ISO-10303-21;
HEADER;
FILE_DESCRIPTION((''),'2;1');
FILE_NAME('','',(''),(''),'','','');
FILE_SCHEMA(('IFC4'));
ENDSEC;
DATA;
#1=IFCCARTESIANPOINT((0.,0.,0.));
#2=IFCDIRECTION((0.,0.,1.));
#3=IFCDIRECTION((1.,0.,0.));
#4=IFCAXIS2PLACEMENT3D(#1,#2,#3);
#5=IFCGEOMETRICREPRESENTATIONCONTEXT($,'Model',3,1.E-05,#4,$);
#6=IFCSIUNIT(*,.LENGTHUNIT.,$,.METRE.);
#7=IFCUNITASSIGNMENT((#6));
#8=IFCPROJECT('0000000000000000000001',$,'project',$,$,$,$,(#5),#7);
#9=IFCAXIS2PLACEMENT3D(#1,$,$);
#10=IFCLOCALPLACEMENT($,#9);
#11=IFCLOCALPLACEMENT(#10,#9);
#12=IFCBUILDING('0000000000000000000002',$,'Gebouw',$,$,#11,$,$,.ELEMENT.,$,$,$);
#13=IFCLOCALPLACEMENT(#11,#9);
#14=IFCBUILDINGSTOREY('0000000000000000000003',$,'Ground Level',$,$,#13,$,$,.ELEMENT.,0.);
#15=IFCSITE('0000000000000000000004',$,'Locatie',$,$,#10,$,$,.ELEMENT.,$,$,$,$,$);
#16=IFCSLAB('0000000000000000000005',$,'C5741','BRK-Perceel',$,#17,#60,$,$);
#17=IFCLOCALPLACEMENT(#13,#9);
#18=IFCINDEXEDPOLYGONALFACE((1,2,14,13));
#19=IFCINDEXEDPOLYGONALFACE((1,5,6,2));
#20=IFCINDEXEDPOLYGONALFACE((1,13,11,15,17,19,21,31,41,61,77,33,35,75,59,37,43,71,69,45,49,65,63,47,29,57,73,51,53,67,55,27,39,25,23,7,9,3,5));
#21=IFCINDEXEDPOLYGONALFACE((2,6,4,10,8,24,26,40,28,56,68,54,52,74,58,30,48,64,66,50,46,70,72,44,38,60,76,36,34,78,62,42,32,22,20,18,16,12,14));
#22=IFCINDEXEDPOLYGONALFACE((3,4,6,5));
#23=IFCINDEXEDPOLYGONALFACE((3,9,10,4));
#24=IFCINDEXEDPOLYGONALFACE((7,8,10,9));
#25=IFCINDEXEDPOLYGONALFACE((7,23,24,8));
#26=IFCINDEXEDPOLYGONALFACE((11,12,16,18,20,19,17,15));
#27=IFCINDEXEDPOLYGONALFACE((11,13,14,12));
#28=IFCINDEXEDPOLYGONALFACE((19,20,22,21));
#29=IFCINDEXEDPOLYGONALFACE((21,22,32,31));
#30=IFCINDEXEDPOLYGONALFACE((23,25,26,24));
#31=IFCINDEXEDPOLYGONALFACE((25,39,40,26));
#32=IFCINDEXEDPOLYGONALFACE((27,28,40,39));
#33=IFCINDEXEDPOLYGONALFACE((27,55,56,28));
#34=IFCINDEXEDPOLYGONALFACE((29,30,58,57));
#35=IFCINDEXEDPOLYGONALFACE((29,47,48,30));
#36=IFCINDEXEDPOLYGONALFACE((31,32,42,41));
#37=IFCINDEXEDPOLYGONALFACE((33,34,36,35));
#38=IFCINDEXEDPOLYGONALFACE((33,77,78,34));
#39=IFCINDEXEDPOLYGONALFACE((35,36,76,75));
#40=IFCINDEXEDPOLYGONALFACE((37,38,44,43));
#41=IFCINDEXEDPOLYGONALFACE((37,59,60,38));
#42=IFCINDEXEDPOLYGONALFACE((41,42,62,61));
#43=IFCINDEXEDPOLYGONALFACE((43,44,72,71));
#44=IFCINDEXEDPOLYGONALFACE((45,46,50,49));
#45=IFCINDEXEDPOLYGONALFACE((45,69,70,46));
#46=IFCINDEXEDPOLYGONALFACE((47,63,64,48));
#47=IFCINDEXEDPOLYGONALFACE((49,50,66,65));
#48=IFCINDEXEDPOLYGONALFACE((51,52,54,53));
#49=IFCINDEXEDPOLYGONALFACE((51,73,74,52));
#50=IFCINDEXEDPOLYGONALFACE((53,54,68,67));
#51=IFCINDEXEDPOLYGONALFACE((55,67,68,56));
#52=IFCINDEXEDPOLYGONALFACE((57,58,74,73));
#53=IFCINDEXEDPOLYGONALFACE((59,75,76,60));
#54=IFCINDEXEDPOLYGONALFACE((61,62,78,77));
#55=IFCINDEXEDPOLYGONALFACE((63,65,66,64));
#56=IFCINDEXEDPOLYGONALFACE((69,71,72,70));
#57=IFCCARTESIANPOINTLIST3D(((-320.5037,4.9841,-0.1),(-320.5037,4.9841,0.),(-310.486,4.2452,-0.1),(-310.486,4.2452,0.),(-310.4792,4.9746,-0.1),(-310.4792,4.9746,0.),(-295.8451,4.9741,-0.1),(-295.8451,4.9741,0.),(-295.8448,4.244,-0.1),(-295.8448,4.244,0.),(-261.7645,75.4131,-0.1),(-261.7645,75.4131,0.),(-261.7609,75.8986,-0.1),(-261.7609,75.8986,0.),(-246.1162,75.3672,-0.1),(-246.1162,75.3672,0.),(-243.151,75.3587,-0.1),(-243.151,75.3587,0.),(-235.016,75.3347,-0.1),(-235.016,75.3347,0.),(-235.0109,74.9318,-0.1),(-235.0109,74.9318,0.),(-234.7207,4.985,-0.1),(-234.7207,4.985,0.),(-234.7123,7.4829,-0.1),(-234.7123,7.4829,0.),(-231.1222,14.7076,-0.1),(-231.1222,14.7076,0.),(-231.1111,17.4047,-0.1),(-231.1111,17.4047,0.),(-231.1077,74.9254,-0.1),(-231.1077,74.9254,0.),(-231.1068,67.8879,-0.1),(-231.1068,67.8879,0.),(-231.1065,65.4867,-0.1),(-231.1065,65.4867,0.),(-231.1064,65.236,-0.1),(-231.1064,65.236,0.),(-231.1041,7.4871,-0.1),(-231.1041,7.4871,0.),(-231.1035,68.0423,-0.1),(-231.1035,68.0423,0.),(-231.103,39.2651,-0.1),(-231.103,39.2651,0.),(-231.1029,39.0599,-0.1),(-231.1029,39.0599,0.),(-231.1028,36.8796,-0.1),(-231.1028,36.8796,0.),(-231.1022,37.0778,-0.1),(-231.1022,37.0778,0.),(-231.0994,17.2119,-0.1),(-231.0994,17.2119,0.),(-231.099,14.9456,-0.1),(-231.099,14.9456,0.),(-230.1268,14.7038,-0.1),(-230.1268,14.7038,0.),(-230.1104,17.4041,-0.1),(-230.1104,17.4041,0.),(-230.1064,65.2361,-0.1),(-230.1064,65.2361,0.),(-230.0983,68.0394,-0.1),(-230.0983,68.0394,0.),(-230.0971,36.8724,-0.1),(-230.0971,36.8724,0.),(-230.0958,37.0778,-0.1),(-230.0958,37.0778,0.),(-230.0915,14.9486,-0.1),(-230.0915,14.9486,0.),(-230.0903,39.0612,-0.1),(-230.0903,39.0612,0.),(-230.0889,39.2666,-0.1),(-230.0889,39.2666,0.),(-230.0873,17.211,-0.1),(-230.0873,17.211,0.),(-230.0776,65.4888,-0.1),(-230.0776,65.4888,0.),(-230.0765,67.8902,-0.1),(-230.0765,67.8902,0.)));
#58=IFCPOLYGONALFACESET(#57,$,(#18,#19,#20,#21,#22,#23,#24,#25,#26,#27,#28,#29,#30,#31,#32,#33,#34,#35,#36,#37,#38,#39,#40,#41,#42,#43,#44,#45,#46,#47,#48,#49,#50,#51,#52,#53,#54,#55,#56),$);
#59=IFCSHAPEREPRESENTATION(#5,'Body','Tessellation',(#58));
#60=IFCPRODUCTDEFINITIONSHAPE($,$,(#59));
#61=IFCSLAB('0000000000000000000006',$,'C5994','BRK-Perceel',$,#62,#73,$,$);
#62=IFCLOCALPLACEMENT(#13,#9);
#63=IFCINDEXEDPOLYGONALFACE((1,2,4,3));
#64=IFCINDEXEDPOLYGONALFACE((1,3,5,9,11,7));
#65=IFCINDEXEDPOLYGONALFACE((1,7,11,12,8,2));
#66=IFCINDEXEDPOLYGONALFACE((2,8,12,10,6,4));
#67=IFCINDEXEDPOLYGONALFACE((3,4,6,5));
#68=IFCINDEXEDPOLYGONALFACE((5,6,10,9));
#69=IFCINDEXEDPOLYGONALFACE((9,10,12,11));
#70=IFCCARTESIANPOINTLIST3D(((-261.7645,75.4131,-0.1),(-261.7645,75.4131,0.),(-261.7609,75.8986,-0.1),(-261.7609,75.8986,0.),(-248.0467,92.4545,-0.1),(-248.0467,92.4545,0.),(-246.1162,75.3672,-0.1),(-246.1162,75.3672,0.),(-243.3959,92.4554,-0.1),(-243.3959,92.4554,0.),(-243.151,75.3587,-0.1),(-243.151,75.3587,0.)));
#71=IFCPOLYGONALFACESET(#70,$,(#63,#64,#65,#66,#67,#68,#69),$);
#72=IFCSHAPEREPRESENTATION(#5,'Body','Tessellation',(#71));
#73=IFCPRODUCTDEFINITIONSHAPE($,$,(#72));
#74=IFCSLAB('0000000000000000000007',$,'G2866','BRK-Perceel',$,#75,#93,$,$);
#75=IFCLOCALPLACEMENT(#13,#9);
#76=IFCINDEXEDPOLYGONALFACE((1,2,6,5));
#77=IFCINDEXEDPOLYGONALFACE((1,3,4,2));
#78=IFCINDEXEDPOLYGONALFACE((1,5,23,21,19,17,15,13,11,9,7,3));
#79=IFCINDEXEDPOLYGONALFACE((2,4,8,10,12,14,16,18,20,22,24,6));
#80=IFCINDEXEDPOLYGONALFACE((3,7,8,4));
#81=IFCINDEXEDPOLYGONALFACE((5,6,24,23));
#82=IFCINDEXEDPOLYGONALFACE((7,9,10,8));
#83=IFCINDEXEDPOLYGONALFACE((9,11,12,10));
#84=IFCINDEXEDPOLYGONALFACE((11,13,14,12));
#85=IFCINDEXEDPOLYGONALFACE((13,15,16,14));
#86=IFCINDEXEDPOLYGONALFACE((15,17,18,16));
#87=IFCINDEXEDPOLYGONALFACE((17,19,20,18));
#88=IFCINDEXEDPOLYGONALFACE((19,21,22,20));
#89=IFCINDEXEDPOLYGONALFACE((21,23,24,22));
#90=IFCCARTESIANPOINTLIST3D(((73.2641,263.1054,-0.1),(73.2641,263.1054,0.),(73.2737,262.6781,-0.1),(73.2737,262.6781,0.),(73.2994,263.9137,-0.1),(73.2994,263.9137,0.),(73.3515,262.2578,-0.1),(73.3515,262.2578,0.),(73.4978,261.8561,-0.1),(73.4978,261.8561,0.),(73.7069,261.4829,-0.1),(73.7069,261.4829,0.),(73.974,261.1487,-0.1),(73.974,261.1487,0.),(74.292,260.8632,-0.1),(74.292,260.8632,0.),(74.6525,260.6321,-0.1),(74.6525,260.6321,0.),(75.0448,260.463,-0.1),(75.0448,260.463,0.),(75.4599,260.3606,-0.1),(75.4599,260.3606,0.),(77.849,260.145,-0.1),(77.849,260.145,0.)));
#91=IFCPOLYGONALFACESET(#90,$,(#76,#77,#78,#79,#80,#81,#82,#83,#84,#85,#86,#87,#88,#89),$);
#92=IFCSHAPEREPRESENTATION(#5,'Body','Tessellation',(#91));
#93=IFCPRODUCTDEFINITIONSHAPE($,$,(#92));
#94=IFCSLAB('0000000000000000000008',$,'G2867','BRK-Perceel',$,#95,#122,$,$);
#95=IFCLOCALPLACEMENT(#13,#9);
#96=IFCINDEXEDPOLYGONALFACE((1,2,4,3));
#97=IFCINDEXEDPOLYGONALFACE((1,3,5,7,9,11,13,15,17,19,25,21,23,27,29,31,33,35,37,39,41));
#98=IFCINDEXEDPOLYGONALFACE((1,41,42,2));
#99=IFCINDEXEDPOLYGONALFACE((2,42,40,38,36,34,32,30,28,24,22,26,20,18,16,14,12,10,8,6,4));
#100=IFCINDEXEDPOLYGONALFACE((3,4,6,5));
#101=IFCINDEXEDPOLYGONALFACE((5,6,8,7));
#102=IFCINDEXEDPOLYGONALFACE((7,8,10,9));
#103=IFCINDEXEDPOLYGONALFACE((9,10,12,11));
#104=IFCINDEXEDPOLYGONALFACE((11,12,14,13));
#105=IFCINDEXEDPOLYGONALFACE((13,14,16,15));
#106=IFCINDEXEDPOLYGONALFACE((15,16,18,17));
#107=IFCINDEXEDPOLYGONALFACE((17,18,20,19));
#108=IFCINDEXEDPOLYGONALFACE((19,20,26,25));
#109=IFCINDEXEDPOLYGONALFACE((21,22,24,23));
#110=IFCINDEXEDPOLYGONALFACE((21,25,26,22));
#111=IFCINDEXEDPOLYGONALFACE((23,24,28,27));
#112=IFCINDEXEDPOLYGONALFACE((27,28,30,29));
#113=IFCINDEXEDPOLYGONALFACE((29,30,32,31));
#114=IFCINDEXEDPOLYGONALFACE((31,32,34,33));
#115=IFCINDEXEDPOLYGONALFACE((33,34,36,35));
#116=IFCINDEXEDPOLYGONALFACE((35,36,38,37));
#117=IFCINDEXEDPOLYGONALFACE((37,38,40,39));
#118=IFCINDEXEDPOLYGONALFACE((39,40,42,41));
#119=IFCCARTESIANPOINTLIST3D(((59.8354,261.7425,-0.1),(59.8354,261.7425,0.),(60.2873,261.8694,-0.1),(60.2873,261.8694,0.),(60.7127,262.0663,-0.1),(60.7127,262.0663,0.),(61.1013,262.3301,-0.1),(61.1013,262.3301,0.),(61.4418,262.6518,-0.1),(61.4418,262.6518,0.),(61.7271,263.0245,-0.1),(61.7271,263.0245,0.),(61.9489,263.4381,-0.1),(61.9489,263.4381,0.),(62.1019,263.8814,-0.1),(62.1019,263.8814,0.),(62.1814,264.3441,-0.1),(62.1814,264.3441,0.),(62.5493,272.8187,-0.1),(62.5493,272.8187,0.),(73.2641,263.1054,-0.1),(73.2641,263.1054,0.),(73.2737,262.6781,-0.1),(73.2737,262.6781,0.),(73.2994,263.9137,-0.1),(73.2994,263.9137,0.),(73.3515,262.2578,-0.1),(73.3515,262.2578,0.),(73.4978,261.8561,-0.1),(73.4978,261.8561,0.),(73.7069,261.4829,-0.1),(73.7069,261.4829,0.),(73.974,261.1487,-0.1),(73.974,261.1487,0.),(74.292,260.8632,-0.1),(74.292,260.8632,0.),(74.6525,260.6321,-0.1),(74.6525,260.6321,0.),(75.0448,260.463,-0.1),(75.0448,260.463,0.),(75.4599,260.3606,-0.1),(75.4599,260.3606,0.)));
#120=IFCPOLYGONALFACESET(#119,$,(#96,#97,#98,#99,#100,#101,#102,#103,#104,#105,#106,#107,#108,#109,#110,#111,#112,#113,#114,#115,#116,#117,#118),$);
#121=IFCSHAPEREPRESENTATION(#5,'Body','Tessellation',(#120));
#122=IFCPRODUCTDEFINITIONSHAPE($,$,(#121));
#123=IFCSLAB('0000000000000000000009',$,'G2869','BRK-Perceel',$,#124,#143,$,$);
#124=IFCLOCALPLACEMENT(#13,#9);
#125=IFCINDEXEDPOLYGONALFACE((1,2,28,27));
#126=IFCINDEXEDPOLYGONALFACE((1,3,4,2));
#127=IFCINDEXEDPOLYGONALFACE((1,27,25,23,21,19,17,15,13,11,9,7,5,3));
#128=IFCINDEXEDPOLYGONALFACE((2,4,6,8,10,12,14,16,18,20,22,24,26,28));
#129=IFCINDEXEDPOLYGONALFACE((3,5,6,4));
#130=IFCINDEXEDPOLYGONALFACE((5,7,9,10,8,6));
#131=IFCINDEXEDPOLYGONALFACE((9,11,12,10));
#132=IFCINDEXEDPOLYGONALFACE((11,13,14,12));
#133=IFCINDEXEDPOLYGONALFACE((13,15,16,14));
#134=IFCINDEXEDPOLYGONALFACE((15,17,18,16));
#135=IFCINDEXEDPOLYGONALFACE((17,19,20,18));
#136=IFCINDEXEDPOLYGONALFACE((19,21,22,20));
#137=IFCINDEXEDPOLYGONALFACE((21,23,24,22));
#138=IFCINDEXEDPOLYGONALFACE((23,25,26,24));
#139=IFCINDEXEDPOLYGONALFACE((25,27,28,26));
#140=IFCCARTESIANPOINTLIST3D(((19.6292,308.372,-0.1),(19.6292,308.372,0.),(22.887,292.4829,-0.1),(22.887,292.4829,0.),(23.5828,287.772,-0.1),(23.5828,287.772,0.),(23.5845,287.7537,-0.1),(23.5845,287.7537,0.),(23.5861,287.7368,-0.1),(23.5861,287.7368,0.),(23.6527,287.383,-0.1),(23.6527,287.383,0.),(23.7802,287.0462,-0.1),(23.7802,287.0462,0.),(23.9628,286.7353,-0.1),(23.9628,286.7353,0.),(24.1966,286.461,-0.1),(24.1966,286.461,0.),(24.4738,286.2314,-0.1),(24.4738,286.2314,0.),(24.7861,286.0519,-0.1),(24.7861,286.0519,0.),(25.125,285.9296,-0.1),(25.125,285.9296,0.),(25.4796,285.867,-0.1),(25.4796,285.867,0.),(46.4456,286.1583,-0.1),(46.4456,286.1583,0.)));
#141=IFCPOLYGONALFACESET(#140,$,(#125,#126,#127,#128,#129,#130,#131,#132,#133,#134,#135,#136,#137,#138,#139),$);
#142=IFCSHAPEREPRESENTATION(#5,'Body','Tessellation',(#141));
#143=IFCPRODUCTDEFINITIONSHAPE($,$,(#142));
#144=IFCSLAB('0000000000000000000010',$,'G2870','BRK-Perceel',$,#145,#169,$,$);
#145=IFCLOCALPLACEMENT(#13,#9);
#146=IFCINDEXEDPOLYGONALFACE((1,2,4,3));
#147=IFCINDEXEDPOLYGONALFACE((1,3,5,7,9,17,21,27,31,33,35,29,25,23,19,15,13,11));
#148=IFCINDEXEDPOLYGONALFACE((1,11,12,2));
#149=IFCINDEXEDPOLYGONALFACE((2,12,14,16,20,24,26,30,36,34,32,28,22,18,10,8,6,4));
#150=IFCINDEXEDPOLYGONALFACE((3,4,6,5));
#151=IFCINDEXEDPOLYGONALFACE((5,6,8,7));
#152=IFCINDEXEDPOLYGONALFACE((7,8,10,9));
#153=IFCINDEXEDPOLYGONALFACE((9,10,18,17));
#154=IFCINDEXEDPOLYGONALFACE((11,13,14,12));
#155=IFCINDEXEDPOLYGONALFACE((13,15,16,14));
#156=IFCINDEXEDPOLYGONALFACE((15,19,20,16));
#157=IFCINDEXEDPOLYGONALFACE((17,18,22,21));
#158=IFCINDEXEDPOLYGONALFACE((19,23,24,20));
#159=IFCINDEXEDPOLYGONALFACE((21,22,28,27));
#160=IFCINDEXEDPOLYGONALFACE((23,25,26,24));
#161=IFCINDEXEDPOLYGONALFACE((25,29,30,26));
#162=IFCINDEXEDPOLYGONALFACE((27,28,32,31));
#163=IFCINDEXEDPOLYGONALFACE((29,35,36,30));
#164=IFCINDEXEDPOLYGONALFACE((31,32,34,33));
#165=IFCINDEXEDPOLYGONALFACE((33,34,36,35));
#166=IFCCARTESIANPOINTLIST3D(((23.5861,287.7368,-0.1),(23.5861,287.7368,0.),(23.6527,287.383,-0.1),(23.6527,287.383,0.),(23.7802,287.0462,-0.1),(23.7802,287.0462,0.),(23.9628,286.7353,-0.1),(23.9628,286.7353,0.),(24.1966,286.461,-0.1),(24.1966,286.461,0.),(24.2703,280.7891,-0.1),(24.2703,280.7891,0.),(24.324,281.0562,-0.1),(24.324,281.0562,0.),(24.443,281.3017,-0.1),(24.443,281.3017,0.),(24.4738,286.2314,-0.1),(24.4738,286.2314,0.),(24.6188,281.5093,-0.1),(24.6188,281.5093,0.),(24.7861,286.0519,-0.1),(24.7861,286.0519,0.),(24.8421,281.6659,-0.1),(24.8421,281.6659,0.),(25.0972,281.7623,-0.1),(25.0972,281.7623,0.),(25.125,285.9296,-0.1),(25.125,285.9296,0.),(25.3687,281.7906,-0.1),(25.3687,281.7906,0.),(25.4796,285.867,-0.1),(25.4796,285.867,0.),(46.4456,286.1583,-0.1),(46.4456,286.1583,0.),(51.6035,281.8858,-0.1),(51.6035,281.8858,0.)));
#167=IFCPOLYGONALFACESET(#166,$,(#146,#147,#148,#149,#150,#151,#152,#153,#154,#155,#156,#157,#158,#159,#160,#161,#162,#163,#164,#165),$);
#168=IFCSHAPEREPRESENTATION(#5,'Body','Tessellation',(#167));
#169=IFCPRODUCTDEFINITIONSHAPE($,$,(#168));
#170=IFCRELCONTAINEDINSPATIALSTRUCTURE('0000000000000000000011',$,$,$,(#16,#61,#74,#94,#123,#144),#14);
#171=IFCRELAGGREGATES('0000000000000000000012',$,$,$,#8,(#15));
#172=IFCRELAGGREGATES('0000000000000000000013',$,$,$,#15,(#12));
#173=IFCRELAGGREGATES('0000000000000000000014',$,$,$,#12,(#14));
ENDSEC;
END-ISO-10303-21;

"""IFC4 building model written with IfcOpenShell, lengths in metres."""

from ifc_helpers import new_model, si_unit, frame, origin, origin_with_axes, place, context, project, spatial, polyline, outline, extrude, element, save


model = new_model("IFC4")

# Units and contexts
model_context = context("Model", 3, precision=1e-05, world=origin_with_axes())
ifc_project = project(units=[si_unit("LENGTHUNIT", "METRE")], contexts=[model_context])

# Site, building, storey
site_placement = place(None, origin())
site = spatial("IfcSite", under=ifc_project, at=site_placement, Name="Locatie", CompositionType="ELEMENT")
building_placement = place(site_placement, origin())
building = spatial("IfcBuilding", under=site, at=building_placement, Name="Gebouw", CompositionType="ELEMENT")
storey_placement = place(building_placement, origin())
storey = spatial("IfcBuildingStorey", under=building, at=storey_placement, Name="Ground Level", CompositionType="ELEMENT", Elevation=0.0)

# Slabs
slab_1_placement = place(storey_placement, origin())
element("IfcSlab", 1, at=slab_1_placement, inside=storey, Name="C5741", Description="BRK-Perceel", context=model_context, shape_type="SweptSolid", body=[
    extrude(outline(polyline([(-261.7645, 75.4131), (-246.1162, 75.3672), (-243.151, 75.3587), (-235.016, 75.3347), (-235.0109, 74.9318), (-231.1077, 74.9254), (-231.1035, 68.0423), (-230.0983, 68.0394), (-230.0765, 67.8902), (-231.1068, 67.8879), (-231.1065, 65.4867), (-230.0776, 65.4888), (-230.1064, 65.2361), (-231.1064, 65.236), (-231.103, 39.2651), (-230.0889, 39.2666), (-230.0903, 39.0612), (-231.1029, 39.0599), (-231.1022, 37.0778), (-230.0958, 37.0778), (-230.0971, 36.8724), (-231.1028, 36.8796), (-231.1111, 17.4047), (-230.1104, 17.4041), (-230.0873, 17.211), (-231.0994, 17.2119), (-231.099, 14.9456), (-230.0915, 14.9486), (-230.1268, 14.7038), (-231.1222, 14.7076), (-231.1041, 7.4871), (-234.7123, 7.4829), (-234.7207, 4.985), (-295.8451, 4.9741), (-295.8448, 4.244), (-310.486, 4.2452), (-310.4792, 4.9746), (-320.5037, 4.9841), (-261.7609, 75.8986), (-261.7645, 75.4131)])), frame((0.0, 0.0, -0.1), z_axis=(0.0, 0.0, 1.0), x_axis=(1.0, 0.0, 0.0)), (0.0, 0.0, 1.0), 0.1),
])
slab_2_placement = place(storey_placement, origin())
element("IfcSlab", 2, at=slab_2_placement, inside=storey, Name="C5994", Description="BRK-Perceel", context=model_context, shape_type="SweptSolid", body=[
    extrude(outline(polyline([(-243.3959, 92.4554), (-243.151, 75.3587), (-246.1162, 75.3672), (-261.7645, 75.4131), (-261.7609, 75.8986), (-248.0467, 92.4545), (-243.3959, 92.4554)])), frame((0.0, 0.0, -0.1), z_axis=(0.0, 0.0, 1.0), x_axis=(1.0, 0.0, 0.0)), (0.0, 0.0, 1.0), 0.1),
])
slab_3_placement = place(storey_placement, origin())
element("IfcSlab", 3, at=slab_3_placement, inside=storey, Name="G2866", Description="BRK-Perceel", context=model_context, shape_type="SweptSolid", body=[
    extrude(outline(polyline([(75.4599, 260.3606), (75.0448, 260.463), (74.6525, 260.6321), (74.292, 260.8632), (73.974, 261.1487), (73.7069, 261.4829), (73.4978, 261.8561), (73.3515, 262.2578), (73.2737, 262.6781), (73.2641, 263.1054), (73.2994, 263.9137), (77.849, 260.145), (75.4599, 260.3606)])), frame((0.0, 0.0, -0.1), z_axis=(0.0, 0.0, 1.0), x_axis=(1.0, 0.0, 0.0)), (0.0, 0.0, 1.0), 0.1),
])
slab_4_placement = place(storey_placement, origin())
element("IfcSlab", 4, at=slab_4_placement, inside=storey, Name="G2867", Description="BRK-Perceel", context=model_context, shape_type="SweptSolid", body=[
    extrude(outline(polyline([(73.2641, 263.1054), (73.2737, 262.6781), (73.3515, 262.2578), (73.4978, 261.8561), (73.7069, 261.4829), (73.974, 261.1487), (74.292, 260.8632), (74.6525, 260.6321), (75.0448, 260.463), (75.4599, 260.3606), (59.8354, 261.7425), (60.2873, 261.8694), (60.7127, 262.0663), (61.1013, 262.3301), (61.4418, 262.6518), (61.7271, 263.0245), (61.9489, 263.4381), (62.1019, 263.8814), (62.1814, 264.3441), (62.5493, 272.8187), (73.2994, 263.9137), (73.2641, 263.1054)])), frame((0.0, 0.0, -0.1), z_axis=(0.0, 0.0, 1.0), x_axis=(1.0, 0.0, 0.0)), (0.0, 0.0, 1.0), 0.1),
])
slab_5_placement = place(storey_placement, origin())
element("IfcSlab", 5, at=slab_5_placement, inside=storey, Name="G2869", Description="BRK-Perceel", context=model_context, shape_type="SweptSolid", body=[
    extrude(outline(polyline([(25.4796, 285.867), (25.125, 285.9296), (24.7861, 286.0519), (24.4738, 286.2314), (24.1966, 286.461), (23.9628, 286.7353), (23.7802, 287.0462), (23.6527, 287.383), (23.5861, 287.7368), (23.5845, 287.7537), (23.5828, 287.772), (22.887, 292.4829), (19.6292, 308.372), (46.4456, 286.1583), (25.4796, 285.867)])), frame((0.0, 0.0, -0.1), z_axis=(0.0, 0.0, 1.0), x_axis=(1.0, 0.0, 0.0)), (0.0, 0.0, 1.0), 0.1),
])
slab_6_placement = place(storey_placement, origin())
element("IfcSlab", 6, at=slab_6_placement, inside=storey, Name="G2870", Description="BRK-Perceel", context=model_context, shape_type="SweptSolid", body=[
    extrude(outline(polyline([(25.3687, 281.7906), (25.0972, 281.7623), (24.8421, 281.6659), (24.6188, 281.5093), (24.443, 281.3017), (24.324, 281.0562), (24.2703, 280.7891), (23.5861, 287.7368), (23.6527, 287.383), (23.7802, 287.0462), (23.9628, 286.7353), (24.1966, 286.461), (24.4738, 286.2314), (24.7861, 286.0519), (25.125, 285.9296), (25.4796, 285.867), (46.4456, 286.1583), (51.6035, 281.8858), (25.3687, 281.7906)])), frame((0.0, 0.0, -0.1), z_axis=(0.0, 0.0, 1.0), x_axis=(1.0, 0.0, 0.0)), (0.0, 0.0, 1.0), 0.1),
])

save(model, "model.ifc")
